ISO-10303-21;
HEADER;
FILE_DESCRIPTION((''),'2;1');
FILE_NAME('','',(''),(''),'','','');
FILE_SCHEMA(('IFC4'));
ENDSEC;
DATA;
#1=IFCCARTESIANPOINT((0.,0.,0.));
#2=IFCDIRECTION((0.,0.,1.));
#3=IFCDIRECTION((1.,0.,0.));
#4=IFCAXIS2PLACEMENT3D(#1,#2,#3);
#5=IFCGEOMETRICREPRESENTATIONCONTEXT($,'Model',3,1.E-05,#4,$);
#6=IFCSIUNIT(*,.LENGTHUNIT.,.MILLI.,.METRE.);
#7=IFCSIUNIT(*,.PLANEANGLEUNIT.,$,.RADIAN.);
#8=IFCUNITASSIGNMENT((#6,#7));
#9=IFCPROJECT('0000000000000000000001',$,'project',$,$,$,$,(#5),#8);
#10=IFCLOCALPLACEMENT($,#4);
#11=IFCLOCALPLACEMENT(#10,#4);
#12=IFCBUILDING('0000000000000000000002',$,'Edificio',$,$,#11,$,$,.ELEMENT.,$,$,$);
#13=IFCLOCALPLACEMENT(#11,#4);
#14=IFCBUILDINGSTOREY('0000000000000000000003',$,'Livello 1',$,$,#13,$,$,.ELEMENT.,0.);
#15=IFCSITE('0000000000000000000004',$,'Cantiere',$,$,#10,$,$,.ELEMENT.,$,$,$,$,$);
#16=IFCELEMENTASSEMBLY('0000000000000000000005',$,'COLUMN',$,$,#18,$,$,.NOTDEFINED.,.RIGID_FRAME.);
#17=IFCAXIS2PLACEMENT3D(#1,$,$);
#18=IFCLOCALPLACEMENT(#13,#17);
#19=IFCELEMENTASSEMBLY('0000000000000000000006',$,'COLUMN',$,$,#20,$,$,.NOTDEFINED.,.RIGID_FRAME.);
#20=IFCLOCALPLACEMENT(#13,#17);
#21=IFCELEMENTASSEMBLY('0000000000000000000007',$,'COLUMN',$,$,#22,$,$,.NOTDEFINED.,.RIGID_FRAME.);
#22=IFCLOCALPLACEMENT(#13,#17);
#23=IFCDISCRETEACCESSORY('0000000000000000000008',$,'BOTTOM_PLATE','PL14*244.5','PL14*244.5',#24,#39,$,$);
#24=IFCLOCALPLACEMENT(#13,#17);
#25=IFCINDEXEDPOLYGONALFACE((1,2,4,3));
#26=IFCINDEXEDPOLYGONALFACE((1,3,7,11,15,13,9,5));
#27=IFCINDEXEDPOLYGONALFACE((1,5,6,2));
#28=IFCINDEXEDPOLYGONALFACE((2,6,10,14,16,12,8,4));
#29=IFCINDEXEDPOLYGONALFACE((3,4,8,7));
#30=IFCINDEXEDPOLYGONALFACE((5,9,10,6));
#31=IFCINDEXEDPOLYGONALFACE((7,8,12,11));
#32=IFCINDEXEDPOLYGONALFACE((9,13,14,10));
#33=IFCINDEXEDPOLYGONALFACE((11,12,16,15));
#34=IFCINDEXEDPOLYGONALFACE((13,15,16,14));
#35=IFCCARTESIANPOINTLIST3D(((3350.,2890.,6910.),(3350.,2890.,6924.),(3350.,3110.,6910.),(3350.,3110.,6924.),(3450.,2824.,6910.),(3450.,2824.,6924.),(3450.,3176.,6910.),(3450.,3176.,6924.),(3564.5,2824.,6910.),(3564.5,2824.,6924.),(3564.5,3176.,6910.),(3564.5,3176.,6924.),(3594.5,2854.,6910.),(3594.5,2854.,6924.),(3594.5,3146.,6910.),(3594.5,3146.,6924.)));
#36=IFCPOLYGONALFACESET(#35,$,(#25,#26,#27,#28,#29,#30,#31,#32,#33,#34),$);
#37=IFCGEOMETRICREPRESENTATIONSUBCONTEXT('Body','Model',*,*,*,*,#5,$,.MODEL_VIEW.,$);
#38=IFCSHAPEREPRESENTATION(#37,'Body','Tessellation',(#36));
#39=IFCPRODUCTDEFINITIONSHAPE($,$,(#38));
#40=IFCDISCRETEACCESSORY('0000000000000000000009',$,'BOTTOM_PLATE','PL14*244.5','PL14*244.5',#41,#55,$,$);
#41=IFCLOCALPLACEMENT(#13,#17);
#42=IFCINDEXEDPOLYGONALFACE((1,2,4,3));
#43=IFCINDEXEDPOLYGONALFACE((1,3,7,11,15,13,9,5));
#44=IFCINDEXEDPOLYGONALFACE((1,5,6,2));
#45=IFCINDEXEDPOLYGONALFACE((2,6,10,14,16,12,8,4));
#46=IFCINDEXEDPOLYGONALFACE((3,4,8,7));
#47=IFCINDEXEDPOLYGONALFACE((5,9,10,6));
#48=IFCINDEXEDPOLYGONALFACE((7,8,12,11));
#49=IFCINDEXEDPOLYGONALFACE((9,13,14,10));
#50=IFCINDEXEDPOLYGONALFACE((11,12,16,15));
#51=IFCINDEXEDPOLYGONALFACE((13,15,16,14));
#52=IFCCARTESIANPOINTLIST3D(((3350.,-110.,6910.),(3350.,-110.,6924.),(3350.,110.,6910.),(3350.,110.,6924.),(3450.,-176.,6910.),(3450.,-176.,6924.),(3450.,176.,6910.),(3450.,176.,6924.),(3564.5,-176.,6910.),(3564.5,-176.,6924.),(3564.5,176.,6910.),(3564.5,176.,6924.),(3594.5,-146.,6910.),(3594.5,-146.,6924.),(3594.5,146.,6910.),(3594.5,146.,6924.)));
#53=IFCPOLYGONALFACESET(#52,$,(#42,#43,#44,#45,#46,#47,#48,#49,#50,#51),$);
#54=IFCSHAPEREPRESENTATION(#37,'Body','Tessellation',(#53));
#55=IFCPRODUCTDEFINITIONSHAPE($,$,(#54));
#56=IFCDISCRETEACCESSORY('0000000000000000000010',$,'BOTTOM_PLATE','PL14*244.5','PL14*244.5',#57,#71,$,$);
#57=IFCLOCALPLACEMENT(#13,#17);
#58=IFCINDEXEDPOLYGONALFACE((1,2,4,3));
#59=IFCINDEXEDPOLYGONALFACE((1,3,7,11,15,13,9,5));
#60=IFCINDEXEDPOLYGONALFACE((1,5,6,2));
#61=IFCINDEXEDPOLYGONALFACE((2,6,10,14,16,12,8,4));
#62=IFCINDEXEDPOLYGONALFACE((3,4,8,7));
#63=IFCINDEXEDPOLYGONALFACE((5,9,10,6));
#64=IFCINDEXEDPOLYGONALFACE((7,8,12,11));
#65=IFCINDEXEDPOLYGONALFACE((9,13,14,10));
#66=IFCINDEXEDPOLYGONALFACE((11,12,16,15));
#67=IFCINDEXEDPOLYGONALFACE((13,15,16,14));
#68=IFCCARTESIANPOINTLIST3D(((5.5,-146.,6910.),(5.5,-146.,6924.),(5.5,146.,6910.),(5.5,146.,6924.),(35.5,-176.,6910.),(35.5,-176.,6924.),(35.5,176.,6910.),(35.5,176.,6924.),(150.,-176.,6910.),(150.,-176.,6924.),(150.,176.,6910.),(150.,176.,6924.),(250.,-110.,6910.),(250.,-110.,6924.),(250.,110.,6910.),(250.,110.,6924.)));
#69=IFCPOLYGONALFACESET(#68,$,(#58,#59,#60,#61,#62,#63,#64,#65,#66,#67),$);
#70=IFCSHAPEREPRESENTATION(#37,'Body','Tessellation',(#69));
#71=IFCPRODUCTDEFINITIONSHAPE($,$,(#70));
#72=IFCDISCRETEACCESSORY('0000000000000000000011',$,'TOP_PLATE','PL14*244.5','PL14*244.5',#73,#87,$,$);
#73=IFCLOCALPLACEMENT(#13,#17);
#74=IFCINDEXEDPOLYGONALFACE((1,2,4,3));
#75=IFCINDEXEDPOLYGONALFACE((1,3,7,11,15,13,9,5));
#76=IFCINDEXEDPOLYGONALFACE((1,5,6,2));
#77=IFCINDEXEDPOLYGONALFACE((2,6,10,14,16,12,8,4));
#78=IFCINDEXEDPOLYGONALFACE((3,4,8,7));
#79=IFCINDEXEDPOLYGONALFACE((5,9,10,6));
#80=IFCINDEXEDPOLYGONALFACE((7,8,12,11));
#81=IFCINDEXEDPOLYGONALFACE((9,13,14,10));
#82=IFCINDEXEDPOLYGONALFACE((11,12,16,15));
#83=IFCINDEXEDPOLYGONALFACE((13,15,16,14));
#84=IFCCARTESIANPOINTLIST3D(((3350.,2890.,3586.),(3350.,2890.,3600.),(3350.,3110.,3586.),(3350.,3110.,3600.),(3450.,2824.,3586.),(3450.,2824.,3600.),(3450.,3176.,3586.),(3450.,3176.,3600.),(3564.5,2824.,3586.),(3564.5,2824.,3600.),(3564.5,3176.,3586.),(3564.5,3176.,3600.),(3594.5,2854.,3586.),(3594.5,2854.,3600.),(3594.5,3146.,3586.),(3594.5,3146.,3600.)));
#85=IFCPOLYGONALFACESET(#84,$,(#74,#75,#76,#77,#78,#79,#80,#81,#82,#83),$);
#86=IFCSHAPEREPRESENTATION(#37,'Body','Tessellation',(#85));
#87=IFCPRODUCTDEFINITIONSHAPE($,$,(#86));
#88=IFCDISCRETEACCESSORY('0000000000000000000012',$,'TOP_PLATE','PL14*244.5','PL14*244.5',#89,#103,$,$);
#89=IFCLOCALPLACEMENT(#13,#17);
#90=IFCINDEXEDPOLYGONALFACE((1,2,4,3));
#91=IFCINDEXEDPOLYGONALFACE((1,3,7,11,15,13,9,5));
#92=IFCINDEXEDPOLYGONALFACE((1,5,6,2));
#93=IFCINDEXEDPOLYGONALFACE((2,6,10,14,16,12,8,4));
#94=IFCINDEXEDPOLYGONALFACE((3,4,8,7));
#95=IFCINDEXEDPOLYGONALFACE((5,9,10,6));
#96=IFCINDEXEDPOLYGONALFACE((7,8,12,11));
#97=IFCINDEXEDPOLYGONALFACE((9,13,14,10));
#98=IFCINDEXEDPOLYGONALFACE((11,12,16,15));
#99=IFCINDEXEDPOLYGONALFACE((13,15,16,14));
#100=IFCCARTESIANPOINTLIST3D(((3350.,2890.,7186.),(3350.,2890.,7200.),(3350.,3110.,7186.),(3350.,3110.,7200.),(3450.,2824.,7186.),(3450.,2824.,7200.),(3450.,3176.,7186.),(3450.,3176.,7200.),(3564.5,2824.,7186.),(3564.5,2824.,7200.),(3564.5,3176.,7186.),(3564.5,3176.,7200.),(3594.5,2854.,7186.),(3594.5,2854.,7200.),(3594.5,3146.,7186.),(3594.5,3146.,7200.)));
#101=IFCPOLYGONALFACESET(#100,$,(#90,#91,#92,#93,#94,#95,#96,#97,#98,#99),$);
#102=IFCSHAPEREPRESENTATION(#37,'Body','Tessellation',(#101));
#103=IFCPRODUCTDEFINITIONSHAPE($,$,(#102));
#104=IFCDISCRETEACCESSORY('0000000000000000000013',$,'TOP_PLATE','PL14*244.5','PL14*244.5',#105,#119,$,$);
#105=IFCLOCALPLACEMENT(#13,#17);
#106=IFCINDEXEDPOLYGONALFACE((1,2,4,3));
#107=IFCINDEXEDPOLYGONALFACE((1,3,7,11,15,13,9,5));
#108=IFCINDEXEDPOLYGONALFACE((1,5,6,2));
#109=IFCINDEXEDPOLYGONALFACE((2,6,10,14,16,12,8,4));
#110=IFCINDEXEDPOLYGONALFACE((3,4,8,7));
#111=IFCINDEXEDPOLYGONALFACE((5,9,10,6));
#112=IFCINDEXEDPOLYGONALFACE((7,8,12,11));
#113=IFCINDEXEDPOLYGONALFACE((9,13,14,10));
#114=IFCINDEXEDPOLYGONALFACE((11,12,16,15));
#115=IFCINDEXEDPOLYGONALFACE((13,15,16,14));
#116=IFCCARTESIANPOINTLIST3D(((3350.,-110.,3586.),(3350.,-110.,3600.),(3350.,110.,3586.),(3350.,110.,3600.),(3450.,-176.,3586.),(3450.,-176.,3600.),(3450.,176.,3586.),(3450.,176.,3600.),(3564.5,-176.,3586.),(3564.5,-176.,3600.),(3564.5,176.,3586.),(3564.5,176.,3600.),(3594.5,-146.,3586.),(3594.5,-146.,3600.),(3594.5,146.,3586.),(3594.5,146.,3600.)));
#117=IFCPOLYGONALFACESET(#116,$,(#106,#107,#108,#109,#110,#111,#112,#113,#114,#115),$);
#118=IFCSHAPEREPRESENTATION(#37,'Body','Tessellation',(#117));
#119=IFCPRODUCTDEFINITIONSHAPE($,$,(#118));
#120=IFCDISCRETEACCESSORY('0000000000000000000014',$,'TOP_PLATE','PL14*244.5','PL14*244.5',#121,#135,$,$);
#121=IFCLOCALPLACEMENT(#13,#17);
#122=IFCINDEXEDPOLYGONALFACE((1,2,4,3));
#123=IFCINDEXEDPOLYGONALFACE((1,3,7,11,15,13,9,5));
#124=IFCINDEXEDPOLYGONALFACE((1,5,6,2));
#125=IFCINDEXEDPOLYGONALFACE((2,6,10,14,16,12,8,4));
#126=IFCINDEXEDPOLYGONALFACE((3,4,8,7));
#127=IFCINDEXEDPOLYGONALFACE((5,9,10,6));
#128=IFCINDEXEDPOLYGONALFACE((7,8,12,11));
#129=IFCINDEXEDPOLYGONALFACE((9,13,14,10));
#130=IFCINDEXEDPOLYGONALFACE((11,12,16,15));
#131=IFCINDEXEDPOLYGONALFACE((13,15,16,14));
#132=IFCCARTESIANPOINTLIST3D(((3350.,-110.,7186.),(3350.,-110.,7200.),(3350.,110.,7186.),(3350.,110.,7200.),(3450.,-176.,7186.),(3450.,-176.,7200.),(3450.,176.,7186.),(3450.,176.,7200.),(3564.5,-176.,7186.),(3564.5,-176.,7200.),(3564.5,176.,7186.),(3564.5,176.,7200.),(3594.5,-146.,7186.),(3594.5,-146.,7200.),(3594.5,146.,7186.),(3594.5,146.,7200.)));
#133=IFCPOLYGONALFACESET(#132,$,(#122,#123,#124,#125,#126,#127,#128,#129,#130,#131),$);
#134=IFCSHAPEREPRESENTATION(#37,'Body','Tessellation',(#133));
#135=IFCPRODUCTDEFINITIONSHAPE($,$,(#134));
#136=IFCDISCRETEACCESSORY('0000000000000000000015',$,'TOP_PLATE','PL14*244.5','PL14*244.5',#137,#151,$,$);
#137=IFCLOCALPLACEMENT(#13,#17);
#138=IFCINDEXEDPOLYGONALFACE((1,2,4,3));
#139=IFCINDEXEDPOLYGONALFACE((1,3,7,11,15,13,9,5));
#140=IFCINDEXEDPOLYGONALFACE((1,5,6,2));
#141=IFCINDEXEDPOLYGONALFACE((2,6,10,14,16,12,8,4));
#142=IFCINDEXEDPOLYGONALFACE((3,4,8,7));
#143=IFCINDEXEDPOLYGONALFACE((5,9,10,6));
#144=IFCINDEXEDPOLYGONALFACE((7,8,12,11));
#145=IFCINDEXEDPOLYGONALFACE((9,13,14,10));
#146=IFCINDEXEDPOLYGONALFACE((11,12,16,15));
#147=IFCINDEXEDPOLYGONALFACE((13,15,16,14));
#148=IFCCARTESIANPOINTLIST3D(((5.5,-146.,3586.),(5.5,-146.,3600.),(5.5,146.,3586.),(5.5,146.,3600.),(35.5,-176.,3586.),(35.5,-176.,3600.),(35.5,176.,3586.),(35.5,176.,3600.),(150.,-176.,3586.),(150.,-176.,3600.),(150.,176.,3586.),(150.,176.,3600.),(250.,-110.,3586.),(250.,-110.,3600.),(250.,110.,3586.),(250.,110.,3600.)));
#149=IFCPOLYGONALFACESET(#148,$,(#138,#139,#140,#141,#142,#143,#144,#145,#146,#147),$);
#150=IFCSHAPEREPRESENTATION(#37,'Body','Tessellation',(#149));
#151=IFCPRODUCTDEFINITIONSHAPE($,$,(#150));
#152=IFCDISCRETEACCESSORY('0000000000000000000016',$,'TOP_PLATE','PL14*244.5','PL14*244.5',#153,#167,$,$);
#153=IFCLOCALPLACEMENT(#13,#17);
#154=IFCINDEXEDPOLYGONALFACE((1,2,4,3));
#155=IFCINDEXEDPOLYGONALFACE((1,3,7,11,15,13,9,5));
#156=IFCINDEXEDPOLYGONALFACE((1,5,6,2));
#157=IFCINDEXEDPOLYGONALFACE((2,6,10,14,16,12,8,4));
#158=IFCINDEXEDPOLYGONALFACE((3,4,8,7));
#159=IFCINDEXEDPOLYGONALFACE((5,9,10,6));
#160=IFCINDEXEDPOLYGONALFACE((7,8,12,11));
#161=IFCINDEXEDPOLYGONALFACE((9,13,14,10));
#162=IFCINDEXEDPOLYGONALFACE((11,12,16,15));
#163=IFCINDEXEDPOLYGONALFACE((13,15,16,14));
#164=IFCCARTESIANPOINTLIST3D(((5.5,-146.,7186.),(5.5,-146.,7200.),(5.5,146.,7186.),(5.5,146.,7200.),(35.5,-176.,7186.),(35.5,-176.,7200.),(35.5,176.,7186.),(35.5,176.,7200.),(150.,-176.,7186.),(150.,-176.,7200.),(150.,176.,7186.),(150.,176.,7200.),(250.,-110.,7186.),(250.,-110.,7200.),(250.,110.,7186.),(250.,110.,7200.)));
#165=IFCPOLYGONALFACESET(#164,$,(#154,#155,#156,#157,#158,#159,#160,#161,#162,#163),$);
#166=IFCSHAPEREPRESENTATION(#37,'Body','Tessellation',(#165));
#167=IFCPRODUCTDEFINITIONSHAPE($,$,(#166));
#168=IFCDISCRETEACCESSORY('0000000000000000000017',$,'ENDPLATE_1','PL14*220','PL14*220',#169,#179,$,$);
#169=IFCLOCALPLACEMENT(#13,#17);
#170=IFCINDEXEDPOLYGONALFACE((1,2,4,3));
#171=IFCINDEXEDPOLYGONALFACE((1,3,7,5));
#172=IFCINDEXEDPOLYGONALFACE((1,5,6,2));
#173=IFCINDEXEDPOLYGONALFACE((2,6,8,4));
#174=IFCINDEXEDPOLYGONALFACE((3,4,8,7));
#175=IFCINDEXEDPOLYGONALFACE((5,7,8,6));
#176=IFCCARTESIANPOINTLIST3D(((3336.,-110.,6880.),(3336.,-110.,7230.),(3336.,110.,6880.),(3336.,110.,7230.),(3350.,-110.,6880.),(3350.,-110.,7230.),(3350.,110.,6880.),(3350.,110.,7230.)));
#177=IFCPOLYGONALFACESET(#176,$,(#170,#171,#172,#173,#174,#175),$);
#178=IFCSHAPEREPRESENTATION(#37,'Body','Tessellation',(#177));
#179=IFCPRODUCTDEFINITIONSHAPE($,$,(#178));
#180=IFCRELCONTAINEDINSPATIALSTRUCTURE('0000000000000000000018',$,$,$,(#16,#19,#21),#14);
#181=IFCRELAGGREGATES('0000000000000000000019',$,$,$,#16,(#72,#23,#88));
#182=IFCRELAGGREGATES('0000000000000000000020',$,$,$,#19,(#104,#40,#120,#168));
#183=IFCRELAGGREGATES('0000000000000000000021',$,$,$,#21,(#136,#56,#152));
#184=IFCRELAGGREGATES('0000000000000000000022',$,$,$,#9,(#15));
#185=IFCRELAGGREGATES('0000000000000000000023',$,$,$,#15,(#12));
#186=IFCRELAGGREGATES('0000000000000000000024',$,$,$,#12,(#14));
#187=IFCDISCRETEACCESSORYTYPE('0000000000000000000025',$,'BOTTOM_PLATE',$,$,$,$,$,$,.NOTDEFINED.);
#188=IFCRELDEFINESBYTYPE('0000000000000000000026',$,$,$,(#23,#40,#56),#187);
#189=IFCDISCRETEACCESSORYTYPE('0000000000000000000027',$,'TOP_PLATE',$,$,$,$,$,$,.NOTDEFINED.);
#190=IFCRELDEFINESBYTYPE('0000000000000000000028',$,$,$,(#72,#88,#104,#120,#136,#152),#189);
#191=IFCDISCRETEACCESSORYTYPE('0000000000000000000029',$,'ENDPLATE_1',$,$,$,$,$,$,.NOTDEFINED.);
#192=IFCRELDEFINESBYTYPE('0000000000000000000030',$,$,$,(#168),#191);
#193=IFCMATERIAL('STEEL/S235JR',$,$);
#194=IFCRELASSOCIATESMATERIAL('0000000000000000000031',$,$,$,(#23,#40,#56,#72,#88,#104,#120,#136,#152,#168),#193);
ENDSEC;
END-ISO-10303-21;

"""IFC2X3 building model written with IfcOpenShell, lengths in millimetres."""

from ifc_helpers import new_model, si_unit, frame, origin_with_axes, place, context, subcontext, project, spatial, polyline, outline, extrude, material, type_object, element, aggregate, save


model = new_model("IFC2X3")

# Units and contexts
model_context = context("Model", 3, precision=1e-05, world=origin_with_axes())
body_context = subcontext(model_context, "Body", "Model", "MODEL_VIEW")
ifc_project = project(units=[si_unit("LENGTHUNIT", "METRE", prefix="MILLI"), si_unit("PLANEANGLEUNIT", "RADIAN")], contexts=[model_context])

# Site, building, storey
site_placement = place(None, origin_with_axes())
site = spatial("IfcSite", under=ifc_project, at=site_placement, Name="Cantiere", CompositionType="ELEMENT")
building_placement = place(site_placement, origin_with_axes())
building = spatial("IfcBuilding", under=site, at=building_placement, Name="Edificio", CompositionType="ELEMENT")
storey_placement = place(building_placement, origin_with_axes())
storey = spatial("IfcBuildingStorey", under=building, at=storey_placement, Name="Livello 1", CompositionType="ELEMENT", Elevation=0.0)

# Element assemblies
assembly_1_placement = place(storey_placement, origin_with_axes())
assembly_1 = element("IfcElementAssembly", 1, at=assembly_1_placement, inside=storey, Name="COLUMN", AssemblyPlace="NOTDEFINED", PredefinedType="RIGID_FRAME")
ifc_material = material(Name="STEEL/S235JR")
assembly_2_placement = place(storey_placement, origin_with_axes())
assembly_2 = element("IfcElementAssembly", 2, at=assembly_2_placement, inside=storey, Name="COLUMN", AssemblyPlace="NOTDEFINED", PredefinedType="RIGID_FRAME")
assembly_3_placement = place(storey_placement, origin_with_axes())
assembly_3 = element("IfcElementAssembly", 3, at=assembly_3_placement, inside=storey, Name="COLUMN", AssemblyPlace="NOTDEFINED", PredefinedType="RIGID_FRAME")

# Discrete accessories
discrete_accessory_type_1 = type_object("IfcDiscreteAccessoryType", Name="BOTTOM_PLATE")
discrete_accessory_1_placement = place(assembly_1_placement, frame((3594.5, 2824.0, 6917.0), z_axis=(0.0, 0.0, 1.0), x_axis=(0.0, 1.0, 0.0)))
discrete_accessory_1 = element("IfcDiscreteAccessory", 4, at=discrete_accessory_1_placement, type_object=discrete_accessory_type_1, material=ifc_material, Name="BOTTOM_PLATE", Description="PL14*244.5", ObjectType="PL14*244.5", context=body_context, shape_type="SweptSolid", body=[
    extrude(outline(polyline([(0.0, 30.0), (30.0, 0.0), (322.0, 0.0), (352.0, 30.0), (352.0, 144.5), (286.0, 244.5), (66.0, 244.5), (0.0, 144.5), (0.0, 30.0)])), frame((0.0, 0.0, -7.0), z_axis=(0.0, 0.0, 1.0), x_axis=(1.0, 0.0, 0.0)), (0.0, 0.0, 1.0), 14.0),
])
discrete_accessory_2_placement = place(assembly_2_placement, frame((3594.5, -176.0, 6917.0), z_axis=(0.0, 0.0, 1.0), x_axis=(0.0, 1.0, 0.0)))
discrete_accessory_2 = element("IfcDiscreteAccessory", 5, at=discrete_accessory_2_placement, type_object=discrete_accessory_type_1, material=ifc_material, Name="BOTTOM_PLATE", Description="PL14*244.5", ObjectType="PL14*244.5", context=body_context, shape_type="SweptSolid", body=[
    extrude(outline(polyline([(0.0, 30.0), (30.0, 0.0), (322.0, 0.0), (352.0, 30.0), (352.0, 144.5), (286.0, 244.5), (66.0, 244.5), (0.0, 144.5), (0.0, 30.0)])), frame((0.0, 0.0, -7.0), z_axis=(0.0, 0.0, 1.0), x_axis=(1.0, 0.0, 0.0)), (0.0, 0.0, 1.0), 14.0),
])
discrete_accessory_3_placement = place(assembly_3_placement, frame((5.5, 176.0, 6917.0), z_axis=(0.0, 0.0, 1.0), x_axis=(0.0, -1.0, 0.0)))
discrete_accessory_3 = element("IfcDiscreteAccessory", 6, at=discrete_accessory_3_placement, type_object=discrete_accessory_type_1, material=ifc_material, Name="BOTTOM_PLATE", Description="PL14*244.5", ObjectType="PL14*244.5", context=body_context, shape_type="SweptSolid", body=[
    extrude(outline(polyline([(0.0, 30.0), (30.0, 0.0), (322.0, 0.0), (352.0, 30.0), (352.0, 144.5), (286.0, 244.5), (66.0, 244.5), (0.0, 144.5), (0.0, 30.0)])), frame((0.0, 0.0, -7.0), z_axis=(0.0, 0.0, 1.0), x_axis=(1.0, 0.0, 0.0)), (0.0, 0.0, 1.0), 14.0),
])
discrete_accessory_type_2 = type_object("IfcDiscreteAccessoryType", Name="TOP_PLATE")
discrete_accessory_4_placement = place(assembly_1_placement, frame((3450.0, 2824.0, 3593.0), z_axis=(0.0, 0.0, 1.0), x_axis=(1.0, 0.0, 0.0)))
discrete_accessory_4 = element("IfcDiscreteAccessory", 7, at=discrete_accessory_4_placement, type_object=discrete_accessory_type_2, material=ifc_material, Name="TOP_PLATE", Description="PL14*244.5", ObjectType="PL14*244.5", context=body_context, shape_type="SweptSolid", body=[
    extrude(outline(polyline([(0.0, 0.0), (114.5, 0.0), (144.5, 30.0), (144.5, 322.0), (114.5, 352.0), (0.0, 352.0), (-100.0, 286.0), (-100.0, 66.0), (0.0, 0.0)])), frame((0.0, 0.0, -7.0), z_axis=(0.0, 0.0, 1.0), x_axis=(1.0, 0.0, 0.0)), (0.0, 0.0, 1.0), 14.0),
])
discrete_accessory_5_placement = place(assembly_1_placement, frame((3450.0, 2824.0, 7193.0), z_axis=(0.0, 0.0, 1.0), x_axis=(1.0, 0.0, 0.0)))
discrete_accessory_5 = element("IfcDiscreteAccessory", 8, at=discrete_accessory_5_placement, type_object=discrete_accessory_type_2, material=ifc_material, Name="TOP_PLATE", Description="PL14*244.5", ObjectType="PL14*244.5", context=body_context, shape_type="SweptSolid", body=[
    extrude(outline(polyline([(0.0, 0.0), (114.5, 0.0), (144.5, 30.0), (144.5, 322.0), (114.5, 352.0), (0.0, 352.0), (-100.0, 286.0), (-100.0, 66.0), (0.0, 0.0)])), frame((0.0, 0.0, -7.0), z_axis=(0.0, 0.0, 1.0), x_axis=(1.0, 0.0, 0.0)), (0.0, 0.0, 1.0), 14.0),
])
aggregate(assembly_1, [discrete_accessory_4, discrete_accessory_1, discrete_accessory_5])
discrete_accessory_6_placement = place(assembly_2_placement, frame((3450.0, -176.0, 3593.0), z_axis=(0.0, 0.0, 1.0), x_axis=(1.0, 0.0, 0.0)))
discrete_accessory_6 = element("IfcDiscreteAccessory", 9, at=discrete_accessory_6_placement, type_object=discrete_accessory_type_2, material=ifc_material, Name="TOP_PLATE", Description="PL14*244.5", ObjectType="PL14*244.5", context=body_context, shape_type="SweptSolid", body=[
    extrude(outline(polyline([(0.0, 0.0), (114.5, 0.0), (144.5, 30.0), (144.5, 322.0), (114.5, 352.0), (0.0, 352.0), (-100.0, 286.0), (-100.0, 66.0), (0.0, 0.0)])), frame((0.0, 0.0, -7.0), z_axis=(0.0, 0.0, 1.0), x_axis=(1.0, 0.0, 0.0)), (0.0, 0.0, 1.0), 14.0),
])
discrete_accessory_7_placement = place(assembly_2_placement, frame((3450.0, -176.0, 7193.0), z_axis=(0.0, 0.0, 1.0), x_axis=(1.0, 0.0, 0.0)))
discrete_accessory_7 = element("IfcDiscreteAccessory", 10, at=discrete_accessory_7_placement, type_object=discrete_accessory_type_2, material=ifc_material, Name="TOP_PLATE", Description="PL14*244.5", ObjectType="PL14*244.5", context=body_context, shape_type="SweptSolid", body=[
    extrude(outline(polyline([(0.0, 0.0), (114.5, 0.0), (144.5, 30.0), (144.5, 322.0), (114.5, 352.0), (0.0, 352.0), (-100.0, 286.0), (-100.0, 66.0), (0.0, 0.0)])), frame((0.0, 0.0, -7.0), z_axis=(0.0, 0.0, 1.0), x_axis=(1.0, 0.0, 0.0)), (0.0, 0.0, 1.0), 14.0),
])
discrete_accessory_8_placement = place(assembly_3_placement, frame((150.0, 176.0, 3593.0), z_axis=(0.0, 0.0, 1.0), x_axis=(-1.0, 0.0, 0.0)))
discrete_accessory_8 = element("IfcDiscreteAccessory", 11, at=discrete_accessory_8_placement, type_object=discrete_accessory_type_2, material=ifc_material, Name="TOP_PLATE", Description="PL14*244.5", ObjectType="PL14*244.5", context=body_context, shape_type="SweptSolid", body=[
    extrude(outline(polyline([(0.0, 0.0), (114.5, 0.0), (144.5, 30.0), (144.5, 322.0), (114.5, 352.0), (0.0, 352.0), (-100.0, 286.0), (-100.0, 66.0), (0.0, 0.0)])), frame((0.0, 0.0, -7.0), z_axis=(0.0, 0.0, 1.0), x_axis=(1.0, 0.0, 0.0)), (0.0, 0.0, 1.0), 14.0),
])
discrete_accessory_9_placement = place(assembly_3_placement, frame((150.0, 176.0, 7193.0), z_axis=(0.0, 0.0, 1.0), x_axis=(-1.0, 0.0, 0.0)))
discrete_accessory_9 = element("IfcDiscreteAccessory", 12, at=discrete_accessory_9_placement, type_object=discrete_accessory_type_2, material=ifc_material, Name="TOP_PLATE", Description="PL14*244.5", ObjectType="PL14*244.5", context=body_context, shape_type="SweptSolid", body=[
    extrude(outline(polyline([(0.0, 0.0), (114.5, 0.0), (144.5, 30.0), (144.5, 322.0), (114.5, 352.0), (0.0, 352.0), (-100.0, 286.0), (-100.0, 66.0), (0.0, 0.0)])), frame((0.0, 0.0, -7.0), z_axis=(0.0, 0.0, 1.0), x_axis=(1.0, 0.0, 0.0)), (0.0, 0.0, 1.0), 14.0),
])
discrete_accessory_type_3 = type_object("IfcDiscreteAccessoryType", Name="ENDPLATE_1")
discrete_accessory_10_placement = place(assembly_2_placement, frame((3343.0, -110.0, 6880.0), z_axis=(-1.0, 0.0, 0.0), x_axis=(0.0, 0.0, 1.0)))
discrete_accessory_10 = element("IfcDiscreteAccessory", 13, at=discrete_accessory_10_placement, type_object=discrete_accessory_type_3, material=ifc_material, Name="ENDPLATE_1", Description="PL14*220", ObjectType="PL14*220", context=body_context, shape_type="SweptSolid", body=[
    extrude(outline(polyline([(0.0, 0.0), (350.0, 0.0), (350.0, 220.0), (0.0, 220.0), (0.0, 0.0)])), frame((0.0, 0.0, -7.0), z_axis=(0.0, 0.0, 1.0), x_axis=(1.0, 0.0, 0.0)), (0.0, 0.0, 1.0), 14.0),
])
aggregate(assembly_2, [discrete_accessory_6, discrete_accessory_2, discrete_accessory_7, discrete_accessory_10])
aggregate(assembly_3, [discrete_accessory_8, discrete_accessory_3, discrete_accessory_9])

save(model, "model.ifc")
